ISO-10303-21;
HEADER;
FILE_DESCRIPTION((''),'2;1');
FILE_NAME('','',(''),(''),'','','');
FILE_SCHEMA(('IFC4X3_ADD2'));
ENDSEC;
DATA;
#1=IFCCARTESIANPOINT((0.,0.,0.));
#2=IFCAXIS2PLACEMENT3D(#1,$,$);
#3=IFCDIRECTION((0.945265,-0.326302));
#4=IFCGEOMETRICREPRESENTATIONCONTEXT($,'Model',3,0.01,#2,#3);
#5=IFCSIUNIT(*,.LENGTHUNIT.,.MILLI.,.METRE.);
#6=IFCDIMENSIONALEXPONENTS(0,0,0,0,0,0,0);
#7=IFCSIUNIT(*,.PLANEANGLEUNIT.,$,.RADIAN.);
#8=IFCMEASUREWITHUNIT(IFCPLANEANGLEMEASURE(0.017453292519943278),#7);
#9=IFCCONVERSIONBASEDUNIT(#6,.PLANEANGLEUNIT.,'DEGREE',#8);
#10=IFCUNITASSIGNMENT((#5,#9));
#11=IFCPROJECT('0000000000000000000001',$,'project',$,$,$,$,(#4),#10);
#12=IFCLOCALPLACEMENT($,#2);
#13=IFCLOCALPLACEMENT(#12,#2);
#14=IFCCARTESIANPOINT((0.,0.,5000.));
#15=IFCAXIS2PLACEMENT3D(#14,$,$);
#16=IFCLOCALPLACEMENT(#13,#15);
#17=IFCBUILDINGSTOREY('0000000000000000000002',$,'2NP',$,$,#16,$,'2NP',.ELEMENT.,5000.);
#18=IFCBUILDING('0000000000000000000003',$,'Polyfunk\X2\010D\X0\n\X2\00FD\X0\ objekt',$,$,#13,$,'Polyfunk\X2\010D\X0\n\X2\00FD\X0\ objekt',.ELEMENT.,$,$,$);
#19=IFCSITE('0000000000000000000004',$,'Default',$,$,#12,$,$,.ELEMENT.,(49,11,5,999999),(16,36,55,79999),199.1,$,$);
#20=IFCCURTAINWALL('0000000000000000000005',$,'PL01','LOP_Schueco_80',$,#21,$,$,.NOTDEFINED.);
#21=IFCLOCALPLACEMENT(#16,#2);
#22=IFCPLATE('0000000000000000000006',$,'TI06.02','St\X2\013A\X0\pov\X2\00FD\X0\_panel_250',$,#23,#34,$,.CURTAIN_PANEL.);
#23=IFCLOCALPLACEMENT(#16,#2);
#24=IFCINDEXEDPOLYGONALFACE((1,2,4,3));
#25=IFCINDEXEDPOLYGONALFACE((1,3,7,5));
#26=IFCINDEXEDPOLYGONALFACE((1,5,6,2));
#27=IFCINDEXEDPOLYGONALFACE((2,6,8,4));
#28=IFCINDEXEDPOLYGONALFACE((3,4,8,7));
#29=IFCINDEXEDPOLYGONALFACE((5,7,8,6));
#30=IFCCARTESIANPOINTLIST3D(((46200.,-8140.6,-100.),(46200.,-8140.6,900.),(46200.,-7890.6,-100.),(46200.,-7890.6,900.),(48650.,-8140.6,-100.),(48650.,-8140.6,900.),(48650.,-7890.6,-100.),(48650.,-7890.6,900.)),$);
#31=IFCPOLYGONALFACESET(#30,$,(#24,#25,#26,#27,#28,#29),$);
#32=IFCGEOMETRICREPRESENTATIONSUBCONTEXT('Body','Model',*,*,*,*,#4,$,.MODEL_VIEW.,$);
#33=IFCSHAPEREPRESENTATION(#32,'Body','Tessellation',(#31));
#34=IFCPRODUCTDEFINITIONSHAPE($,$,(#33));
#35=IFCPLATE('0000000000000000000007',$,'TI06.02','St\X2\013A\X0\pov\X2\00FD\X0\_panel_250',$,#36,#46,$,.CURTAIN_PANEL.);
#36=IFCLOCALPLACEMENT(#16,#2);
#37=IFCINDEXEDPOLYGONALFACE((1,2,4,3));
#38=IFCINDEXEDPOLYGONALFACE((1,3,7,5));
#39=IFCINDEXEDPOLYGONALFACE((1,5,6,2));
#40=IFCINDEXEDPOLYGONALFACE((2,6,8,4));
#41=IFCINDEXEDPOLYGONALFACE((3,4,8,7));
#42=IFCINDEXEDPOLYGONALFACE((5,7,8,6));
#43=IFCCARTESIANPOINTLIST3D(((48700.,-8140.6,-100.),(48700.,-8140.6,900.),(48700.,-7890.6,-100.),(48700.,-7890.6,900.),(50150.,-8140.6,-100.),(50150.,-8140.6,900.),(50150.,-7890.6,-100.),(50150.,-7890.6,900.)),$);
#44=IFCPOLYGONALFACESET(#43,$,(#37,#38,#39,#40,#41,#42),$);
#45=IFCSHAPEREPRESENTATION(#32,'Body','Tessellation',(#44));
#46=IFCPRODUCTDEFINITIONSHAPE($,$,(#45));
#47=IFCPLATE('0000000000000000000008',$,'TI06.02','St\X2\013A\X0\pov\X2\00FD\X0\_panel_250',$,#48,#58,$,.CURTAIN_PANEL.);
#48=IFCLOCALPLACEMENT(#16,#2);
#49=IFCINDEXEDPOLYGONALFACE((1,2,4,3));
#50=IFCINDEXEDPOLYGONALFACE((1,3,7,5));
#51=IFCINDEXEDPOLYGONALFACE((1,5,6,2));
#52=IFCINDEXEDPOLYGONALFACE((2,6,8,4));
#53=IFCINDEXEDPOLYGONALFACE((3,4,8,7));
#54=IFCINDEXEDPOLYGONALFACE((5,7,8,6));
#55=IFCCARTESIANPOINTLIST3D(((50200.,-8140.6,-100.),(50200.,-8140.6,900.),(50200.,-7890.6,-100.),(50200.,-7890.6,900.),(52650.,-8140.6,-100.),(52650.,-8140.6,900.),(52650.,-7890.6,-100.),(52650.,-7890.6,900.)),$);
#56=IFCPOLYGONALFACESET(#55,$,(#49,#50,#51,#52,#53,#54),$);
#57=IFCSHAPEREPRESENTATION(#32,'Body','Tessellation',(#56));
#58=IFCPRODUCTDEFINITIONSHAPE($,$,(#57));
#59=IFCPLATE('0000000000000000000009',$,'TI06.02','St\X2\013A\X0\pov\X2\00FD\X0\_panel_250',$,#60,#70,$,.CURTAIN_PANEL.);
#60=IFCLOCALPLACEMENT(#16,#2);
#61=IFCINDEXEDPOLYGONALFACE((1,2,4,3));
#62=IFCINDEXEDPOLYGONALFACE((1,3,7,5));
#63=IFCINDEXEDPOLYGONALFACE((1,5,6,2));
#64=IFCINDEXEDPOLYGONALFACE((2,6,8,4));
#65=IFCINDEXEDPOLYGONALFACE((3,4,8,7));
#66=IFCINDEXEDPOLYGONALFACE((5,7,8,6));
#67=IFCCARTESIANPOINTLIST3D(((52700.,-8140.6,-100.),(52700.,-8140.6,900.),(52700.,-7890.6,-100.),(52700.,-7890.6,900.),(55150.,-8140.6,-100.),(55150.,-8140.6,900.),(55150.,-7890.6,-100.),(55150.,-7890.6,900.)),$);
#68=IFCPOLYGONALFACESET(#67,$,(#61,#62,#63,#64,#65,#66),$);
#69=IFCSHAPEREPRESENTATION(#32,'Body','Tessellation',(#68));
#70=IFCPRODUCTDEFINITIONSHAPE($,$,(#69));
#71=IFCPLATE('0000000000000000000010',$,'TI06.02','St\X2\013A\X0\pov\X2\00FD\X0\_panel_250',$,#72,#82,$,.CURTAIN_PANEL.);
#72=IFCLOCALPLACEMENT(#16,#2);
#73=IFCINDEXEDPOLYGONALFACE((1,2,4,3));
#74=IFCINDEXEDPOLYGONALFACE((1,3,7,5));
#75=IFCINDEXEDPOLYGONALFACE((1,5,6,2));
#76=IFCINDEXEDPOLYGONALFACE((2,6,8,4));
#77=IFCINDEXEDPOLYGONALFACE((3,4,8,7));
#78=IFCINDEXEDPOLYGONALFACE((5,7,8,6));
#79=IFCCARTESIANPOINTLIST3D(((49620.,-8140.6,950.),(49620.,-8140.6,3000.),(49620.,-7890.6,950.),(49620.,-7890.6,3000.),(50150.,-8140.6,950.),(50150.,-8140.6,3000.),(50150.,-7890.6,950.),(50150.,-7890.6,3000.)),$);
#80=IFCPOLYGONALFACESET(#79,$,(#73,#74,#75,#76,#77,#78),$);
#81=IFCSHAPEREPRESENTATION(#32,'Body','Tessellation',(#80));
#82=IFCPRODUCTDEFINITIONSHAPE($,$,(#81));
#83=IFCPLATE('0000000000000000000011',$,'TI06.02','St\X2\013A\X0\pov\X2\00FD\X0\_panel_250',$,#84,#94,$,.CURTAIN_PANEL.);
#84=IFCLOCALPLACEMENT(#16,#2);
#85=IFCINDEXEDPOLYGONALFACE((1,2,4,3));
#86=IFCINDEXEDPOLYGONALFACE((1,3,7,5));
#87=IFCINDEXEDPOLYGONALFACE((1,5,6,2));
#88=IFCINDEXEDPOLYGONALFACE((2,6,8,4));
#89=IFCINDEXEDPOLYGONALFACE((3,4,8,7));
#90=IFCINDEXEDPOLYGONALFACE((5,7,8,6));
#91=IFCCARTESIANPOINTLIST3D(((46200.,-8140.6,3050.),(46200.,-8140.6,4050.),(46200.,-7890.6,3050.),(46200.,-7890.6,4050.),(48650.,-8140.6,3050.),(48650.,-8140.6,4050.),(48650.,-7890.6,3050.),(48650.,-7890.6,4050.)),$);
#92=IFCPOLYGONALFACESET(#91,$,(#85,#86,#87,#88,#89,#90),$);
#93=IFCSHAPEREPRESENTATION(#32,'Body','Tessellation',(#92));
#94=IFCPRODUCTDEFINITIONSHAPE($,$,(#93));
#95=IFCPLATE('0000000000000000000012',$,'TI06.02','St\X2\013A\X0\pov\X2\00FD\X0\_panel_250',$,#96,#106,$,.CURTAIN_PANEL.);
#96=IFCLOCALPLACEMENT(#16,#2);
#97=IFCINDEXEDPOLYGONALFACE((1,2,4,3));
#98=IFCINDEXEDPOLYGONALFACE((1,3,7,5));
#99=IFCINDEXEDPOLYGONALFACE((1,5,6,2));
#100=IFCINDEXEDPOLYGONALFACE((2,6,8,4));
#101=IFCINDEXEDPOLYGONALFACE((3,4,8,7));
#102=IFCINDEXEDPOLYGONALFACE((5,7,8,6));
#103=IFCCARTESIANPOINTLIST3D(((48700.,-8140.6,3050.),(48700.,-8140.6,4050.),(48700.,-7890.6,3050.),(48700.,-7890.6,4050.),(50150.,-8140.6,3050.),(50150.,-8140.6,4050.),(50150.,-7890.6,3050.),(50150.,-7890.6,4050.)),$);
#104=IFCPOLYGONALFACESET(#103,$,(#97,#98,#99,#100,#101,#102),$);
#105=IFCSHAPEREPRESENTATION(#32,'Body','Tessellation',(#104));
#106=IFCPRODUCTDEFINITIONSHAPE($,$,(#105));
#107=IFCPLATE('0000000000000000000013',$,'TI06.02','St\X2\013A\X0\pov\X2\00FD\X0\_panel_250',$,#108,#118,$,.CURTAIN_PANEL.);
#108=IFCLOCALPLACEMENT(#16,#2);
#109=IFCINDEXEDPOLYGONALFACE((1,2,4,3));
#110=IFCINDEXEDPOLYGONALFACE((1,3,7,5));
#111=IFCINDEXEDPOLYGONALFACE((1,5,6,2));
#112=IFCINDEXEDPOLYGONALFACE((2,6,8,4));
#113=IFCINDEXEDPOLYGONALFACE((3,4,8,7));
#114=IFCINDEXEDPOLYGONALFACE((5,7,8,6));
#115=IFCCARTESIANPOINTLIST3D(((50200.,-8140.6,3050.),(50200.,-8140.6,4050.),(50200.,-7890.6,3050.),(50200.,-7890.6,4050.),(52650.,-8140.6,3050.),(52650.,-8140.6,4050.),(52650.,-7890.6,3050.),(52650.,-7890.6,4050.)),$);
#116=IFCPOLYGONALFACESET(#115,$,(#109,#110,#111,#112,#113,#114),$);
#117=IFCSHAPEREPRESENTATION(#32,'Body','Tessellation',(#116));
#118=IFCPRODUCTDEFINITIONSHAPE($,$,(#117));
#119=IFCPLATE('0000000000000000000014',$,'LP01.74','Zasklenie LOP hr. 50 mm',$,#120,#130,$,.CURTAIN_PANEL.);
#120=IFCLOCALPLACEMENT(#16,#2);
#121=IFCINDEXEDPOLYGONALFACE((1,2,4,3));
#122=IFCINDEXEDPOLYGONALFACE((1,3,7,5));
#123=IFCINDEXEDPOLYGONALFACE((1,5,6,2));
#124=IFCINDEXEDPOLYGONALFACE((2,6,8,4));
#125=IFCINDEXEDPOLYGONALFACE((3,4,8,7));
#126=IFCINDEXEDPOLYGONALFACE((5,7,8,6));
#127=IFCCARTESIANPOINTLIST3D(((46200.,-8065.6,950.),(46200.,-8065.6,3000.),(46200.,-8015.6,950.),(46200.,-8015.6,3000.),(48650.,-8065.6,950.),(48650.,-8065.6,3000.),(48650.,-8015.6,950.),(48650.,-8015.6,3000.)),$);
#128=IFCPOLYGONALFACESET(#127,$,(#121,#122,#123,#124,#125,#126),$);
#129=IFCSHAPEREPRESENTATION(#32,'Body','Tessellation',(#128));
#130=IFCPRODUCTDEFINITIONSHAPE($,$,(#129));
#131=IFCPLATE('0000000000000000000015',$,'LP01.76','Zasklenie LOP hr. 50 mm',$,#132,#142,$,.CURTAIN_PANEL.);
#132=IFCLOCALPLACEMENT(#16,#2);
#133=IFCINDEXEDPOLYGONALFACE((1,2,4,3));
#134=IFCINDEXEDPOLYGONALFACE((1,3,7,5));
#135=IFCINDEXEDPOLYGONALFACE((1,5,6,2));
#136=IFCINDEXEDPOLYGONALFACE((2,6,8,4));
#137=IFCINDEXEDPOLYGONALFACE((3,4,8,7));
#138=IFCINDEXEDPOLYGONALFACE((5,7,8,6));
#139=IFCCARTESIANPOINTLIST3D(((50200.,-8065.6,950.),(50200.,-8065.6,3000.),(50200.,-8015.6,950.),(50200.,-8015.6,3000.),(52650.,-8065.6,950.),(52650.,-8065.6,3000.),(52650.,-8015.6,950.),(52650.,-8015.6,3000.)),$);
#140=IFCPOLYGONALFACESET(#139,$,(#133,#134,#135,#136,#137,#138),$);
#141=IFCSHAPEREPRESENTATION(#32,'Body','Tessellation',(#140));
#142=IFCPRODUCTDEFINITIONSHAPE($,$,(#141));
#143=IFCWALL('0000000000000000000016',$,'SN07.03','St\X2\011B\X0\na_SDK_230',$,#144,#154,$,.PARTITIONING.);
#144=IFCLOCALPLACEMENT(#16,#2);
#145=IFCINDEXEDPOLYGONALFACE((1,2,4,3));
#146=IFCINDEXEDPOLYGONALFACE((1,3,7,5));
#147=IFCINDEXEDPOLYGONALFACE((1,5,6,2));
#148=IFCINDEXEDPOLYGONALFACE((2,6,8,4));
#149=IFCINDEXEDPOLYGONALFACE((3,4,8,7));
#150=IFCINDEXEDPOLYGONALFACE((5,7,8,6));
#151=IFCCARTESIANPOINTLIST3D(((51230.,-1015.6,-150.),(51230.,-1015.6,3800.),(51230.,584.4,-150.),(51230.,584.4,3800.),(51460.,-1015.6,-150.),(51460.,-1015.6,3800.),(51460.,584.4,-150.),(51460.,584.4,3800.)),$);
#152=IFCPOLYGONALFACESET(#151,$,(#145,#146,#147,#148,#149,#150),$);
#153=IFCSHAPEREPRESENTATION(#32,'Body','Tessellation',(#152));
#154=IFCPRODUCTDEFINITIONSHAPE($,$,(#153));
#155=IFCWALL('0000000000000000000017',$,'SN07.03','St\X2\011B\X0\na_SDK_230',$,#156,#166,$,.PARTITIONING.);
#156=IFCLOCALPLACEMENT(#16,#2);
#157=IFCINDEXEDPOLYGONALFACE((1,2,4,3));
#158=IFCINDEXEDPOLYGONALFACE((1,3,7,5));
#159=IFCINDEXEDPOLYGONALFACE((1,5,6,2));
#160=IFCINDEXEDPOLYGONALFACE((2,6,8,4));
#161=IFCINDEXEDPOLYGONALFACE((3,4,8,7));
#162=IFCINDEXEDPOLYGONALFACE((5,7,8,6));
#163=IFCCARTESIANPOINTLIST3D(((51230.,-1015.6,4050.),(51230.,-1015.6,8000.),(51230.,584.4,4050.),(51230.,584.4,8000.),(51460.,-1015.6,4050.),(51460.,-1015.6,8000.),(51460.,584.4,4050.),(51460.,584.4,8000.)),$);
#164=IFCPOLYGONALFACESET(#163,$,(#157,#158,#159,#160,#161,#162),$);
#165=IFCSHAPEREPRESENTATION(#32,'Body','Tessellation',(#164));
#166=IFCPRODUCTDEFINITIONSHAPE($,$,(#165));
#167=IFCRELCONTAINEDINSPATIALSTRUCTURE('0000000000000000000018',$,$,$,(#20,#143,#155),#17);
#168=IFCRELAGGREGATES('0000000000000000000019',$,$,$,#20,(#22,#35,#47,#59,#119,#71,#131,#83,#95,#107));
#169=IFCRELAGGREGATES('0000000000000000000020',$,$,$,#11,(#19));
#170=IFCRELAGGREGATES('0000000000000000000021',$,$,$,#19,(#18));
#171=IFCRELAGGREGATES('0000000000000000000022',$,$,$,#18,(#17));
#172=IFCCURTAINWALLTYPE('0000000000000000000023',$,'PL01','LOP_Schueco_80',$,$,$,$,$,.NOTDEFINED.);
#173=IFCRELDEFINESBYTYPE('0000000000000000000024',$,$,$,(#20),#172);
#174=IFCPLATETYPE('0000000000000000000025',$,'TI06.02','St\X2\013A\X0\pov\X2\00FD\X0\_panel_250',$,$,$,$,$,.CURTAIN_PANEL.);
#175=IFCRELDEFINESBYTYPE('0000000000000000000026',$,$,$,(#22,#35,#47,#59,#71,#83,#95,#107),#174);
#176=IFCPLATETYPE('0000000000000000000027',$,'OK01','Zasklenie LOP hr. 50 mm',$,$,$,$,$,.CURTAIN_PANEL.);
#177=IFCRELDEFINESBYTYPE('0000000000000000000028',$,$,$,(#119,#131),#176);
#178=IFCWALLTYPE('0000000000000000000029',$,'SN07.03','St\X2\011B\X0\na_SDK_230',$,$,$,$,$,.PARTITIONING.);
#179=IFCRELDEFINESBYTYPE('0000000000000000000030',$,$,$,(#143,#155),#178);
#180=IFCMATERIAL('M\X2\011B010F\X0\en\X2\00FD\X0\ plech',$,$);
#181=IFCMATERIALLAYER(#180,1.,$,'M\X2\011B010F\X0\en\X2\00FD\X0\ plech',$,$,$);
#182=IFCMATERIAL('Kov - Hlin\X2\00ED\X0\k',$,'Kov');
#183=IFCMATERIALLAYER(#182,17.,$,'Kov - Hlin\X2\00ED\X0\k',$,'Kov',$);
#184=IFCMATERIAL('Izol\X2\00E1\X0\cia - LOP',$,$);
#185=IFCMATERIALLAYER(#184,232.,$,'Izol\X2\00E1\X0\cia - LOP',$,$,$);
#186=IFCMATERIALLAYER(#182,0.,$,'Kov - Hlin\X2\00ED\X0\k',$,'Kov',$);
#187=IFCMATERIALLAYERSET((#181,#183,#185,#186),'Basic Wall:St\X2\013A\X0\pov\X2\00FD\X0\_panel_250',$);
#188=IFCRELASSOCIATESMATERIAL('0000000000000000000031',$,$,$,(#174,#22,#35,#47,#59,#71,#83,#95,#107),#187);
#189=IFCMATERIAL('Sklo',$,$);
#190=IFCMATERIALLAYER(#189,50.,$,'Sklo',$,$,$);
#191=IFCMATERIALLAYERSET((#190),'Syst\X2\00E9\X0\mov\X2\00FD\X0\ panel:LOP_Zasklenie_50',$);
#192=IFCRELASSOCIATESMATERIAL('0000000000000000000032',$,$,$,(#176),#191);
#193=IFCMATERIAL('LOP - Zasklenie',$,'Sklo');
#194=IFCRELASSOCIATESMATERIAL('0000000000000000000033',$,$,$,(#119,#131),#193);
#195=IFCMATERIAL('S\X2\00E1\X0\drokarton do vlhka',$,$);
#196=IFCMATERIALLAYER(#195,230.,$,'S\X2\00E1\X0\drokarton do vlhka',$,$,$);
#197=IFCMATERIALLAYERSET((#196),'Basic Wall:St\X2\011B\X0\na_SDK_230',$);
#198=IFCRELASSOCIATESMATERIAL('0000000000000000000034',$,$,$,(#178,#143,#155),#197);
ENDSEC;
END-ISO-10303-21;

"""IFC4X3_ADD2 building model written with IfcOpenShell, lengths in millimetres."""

from ifc_helpers import new_model, entity, si_unit, converted_unit, direction, frame, frame_2d, origin, origin_2d_with_axis, place, context, subcontext, project, spatial, polyline, rectangle, extrude, clip, bounded_halfspace, source, transform, mapped, material, layer, layer_set, layer_usage, type_object, type_shapes, element, aggregate, save


model = new_model("IFC4X3_ADD2")

# Units and contexts
model_context = context("Model", 3, precision=0.01, world=origin(), true_north=direction((0.945265, -0.326302)))
body_context = subcontext(model_context, "Body", "Model", "MODEL_VIEW")
ifc_project = project(units=[si_unit("LENGTHUNIT", "METRE", prefix="MILLI"), converted_unit("PLANEANGLEUNIT", "DEGREE", entity("IfcPlaneAngleMeasure", 0.017453292519943278), si_unit("PLANEANGLEUNIT", "RADIAN"), dimensions=[0, 0, 0, 0, 0, 0, 0])], contexts=[model_context])

# Site, building, storey
site_placement = place(None, origin())
site = spatial("IfcSite", under=ifc_project, at=site_placement, Name="Default", CompositionType="ELEMENT", RefLatitude=(49, 11, 5, 999999), RefLongitude=(16, 36, 55, 79999), RefElevation=199.1)
building_placement = place(site_placement, origin())
building = spatial("IfcBuilding", under=site, at=building_placement, Name="Polyfunkčný objekt", LongName="Polyfunkčný objekt", CompositionType="ELEMENT")
storey_placement = place(building_placement, frame((0.0, 0.0, 5000.0)))
storey = spatial("IfcBuildingStorey", under=building, at=storey_placement, Name="2NP", LongName="2NP", CompositionType="ELEMENT", Elevation=5000.0)

# Curtain wall, plates
curtain_wall_type = type_object("IfcCurtainWallType", Name="PL01", Description="LOP_Schueco_80", PredefinedType="NOTDEFINED")
curtain_wall_placement = place(storey_placement, frame((0.0, 0.0, -5000.0)))
curtain_wall = element("IfcCurtainWall", 1, at=curtain_wall_placement, inside=storey, type_object=curtain_wall_type, Name="PL01", Description="LOP_Schueco_80", PredefinedType="NOTDEFINED")
ifc_material_1 = material(Name="Měďený plech")
ifc_layer_1 = layer(ifc_material_1, 1.0, Name="Měďený plech")
ifc_material_2 = material(Name="Kov - Hliník", Category="Kov")
ifc_layer_2 = layer(ifc_material_2, 17.0, Name="Kov - Hliník", Category="Kov")
ifc_material_3 = material(Name="Izolácia - LOP")
ifc_layer_3 = layer(ifc_material_3, 232.0, Name="Izolácia - LOP")
ifc_layer_4 = layer(ifc_material_2, 0.0, Name="Kov - Hliník", Category="Kov")
ifc_layer_set_1 = layer_set([ifc_layer_1, ifc_layer_2, ifc_layer_3, ifc_layer_4], Name="Basic Wall:Stĺpový_panel_250")
ifc_layer_usage_1 = layer_usage(ifc_layer_set_1, "AXIS2", "POSITIVE", -125.0)
plate_type_1 = type_object("IfcPlateType", Name="TI06.02", Description="Stĺpový_panel_250", PredefinedType="CURTAIN_PANEL", material=ifc_layer_set_1)
plate_1_placement = place(storey_placement, frame((46200.0, -8015.6, -100.0)))
plate_1 = element("IfcPlate", 2, at=plate_1_placement, type_object=plate_type_1, material=ifc_layer_usage_1, Name="TI06.02", Description="Stĺpový_panel_250", PredefinedType="CURTAIN_PANEL", context=body_context, shape_type="SweptSolid", body=[
    extrude(rectangle(XDim=250.0, YDim=2450.0, at=frame_2d((0.0, 0.0), x_axis=(1.0, 0.0))), frame((1225.0, 0.0, 0.0), z_axis=(0.0, 0.0, 1.0), x_axis=(0.0, 1.0, 0.0)), (0.0, 0.0, 1.0), 1000.0),
])
ifc_layer_usage_2 = layer_usage(ifc_layer_set_1, "AXIS2", "POSITIVE", -125.0)
plate_2_placement = place(storey_placement, frame((48700.0, -8015.6, -100.0)))
plate_2 = element("IfcPlate", 3, at=plate_2_placement, type_object=plate_type_1, material=ifc_layer_usage_2, Name="TI06.02", Description="Stĺpový_panel_250", PredefinedType="CURTAIN_PANEL", context=body_context, shape_type="SweptSolid", body=[
    extrude(rectangle(XDim=250.0, YDim=1450.0, at=frame_2d((0.0, 0.0), x_axis=(1.0, 0.0))), frame((725.0, 0.0, 0.0), z_axis=(0.0, 0.0, 1.0), x_axis=(0.0, 1.0, 0.0)), (0.0, 0.0, 1.0), 1000.0),
])
ifc_layer_usage_3 = layer_usage(ifc_layer_set_1, "AXIS2", "POSITIVE", -125.0)
plate_3_placement = place(storey_placement, frame((50200.0, -8015.6, -100.0)))
plate_3 = element("IfcPlate", 4, at=plate_3_placement, type_object=plate_type_1, material=ifc_layer_usage_3, Name="TI06.02", Description="Stĺpový_panel_250", PredefinedType="CURTAIN_PANEL", context=body_context, shape_type="SweptSolid", body=[
    extrude(rectangle(XDim=250.0, YDim=2450.0, at=origin_2d_with_axis()), frame((1225.0, 0.0, 0.0), z_axis=(0.0, 0.0, 1.0), x_axis=(0.0, 1.0, 0.0)), (0.0, 0.0, 1.0), 1000.0),
])
ifc_layer_usage_4 = layer_usage(ifc_layer_set_1, "AXIS2", "POSITIVE", -125.0)
plate_4_placement = place(storey_placement, frame((52700.0, -8015.6, -100.0)))
plate_4 = element("IfcPlate", 5, at=plate_4_placement, type_object=plate_type_1, material=ifc_layer_usage_4, Name="TI06.02", Description="Stĺpový_panel_250", PredefinedType="CURTAIN_PANEL", context=body_context, shape_type="SweptSolid", body=[
    extrude(rectangle(XDim=250.0, YDim=2450.0, at=frame_2d((0.0, 0.0), x_axis=(1.0, 0.0))), frame((1225.0, 0.0, 0.0), z_axis=(0.0, 0.0, 1.0), x_axis=(0.0, 1.0, 0.0)), (0.0, 0.0, 1.0), 1000.0),
])
ifc_layer_usage_5 = layer_usage(ifc_layer_set_1, "AXIS2", "POSITIVE", -125.0)
plate_5_placement = place(storey_placement, frame((49620.0, -8015.6, 950.0)))
plate_5 = element("IfcPlate", 6, at=plate_5_placement, type_object=plate_type_1, material=ifc_layer_usage_5, Name="TI06.02", Description="Stĺpový_panel_250", PredefinedType="CURTAIN_PANEL", context=body_context, shape_type="SweptSolid", body=[
    extrude(rectangle(XDim=250.0, YDim=530.0, at=frame_2d((0.0, 0.0), x_axis=(1.0, 0.0))), frame((265.0, 0.0, 0.0), z_axis=(0.0, 0.0, 1.0), x_axis=(0.0, 1.0, 0.0)), (0.0, 0.0, 1.0), 2050.0),
])
ifc_layer_usage_6 = layer_usage(ifc_layer_set_1, "AXIS2", "POSITIVE", -125.0)
plate_6_placement = place(storey_placement, frame((46200.0, -8015.6, 3050.0)))
plate_6 = element("IfcPlate", 7, at=plate_6_placement, type_object=plate_type_1, material=ifc_layer_usage_6, Name="TI06.02", Description="Stĺpový_panel_250", PredefinedType="CURTAIN_PANEL", context=body_context, shape_type="SweptSolid", body=[
    extrude(rectangle(XDim=250.0, YDim=2450.0, at=frame_2d((0.0, 0.0), x_axis=(1.0, 0.0))), frame((1225.0, 0.0, 0.0), z_axis=(0.0, 0.0, 1.0), x_axis=(0.0, 1.0, 0.0)), (0.0, 0.0, 1.0), 1000.0),
])
ifc_layer_usage_7 = layer_usage(ifc_layer_set_1, "AXIS2", "POSITIVE", -125.0)
plate_7_placement = place(storey_placement, frame((48700.0, -8015.6, 3050.0)))
plate_7 = element("IfcPlate", 8, at=plate_7_placement, type_object=plate_type_1, material=ifc_layer_usage_7, Name="TI06.02", Description="Stĺpový_panel_250", PredefinedType="CURTAIN_PANEL", context=body_context, shape_type="SweptSolid", body=[
    extrude(rectangle(XDim=250.0, YDim=1450.0, at=frame_2d((0.0, 0.0), x_axis=(1.0, 0.0))), frame((725.0, 0.0, 0.0), z_axis=(0.0, 0.0, 1.0), x_axis=(0.0, 1.0, 0.0)), (0.0, 0.0, 1.0), 1000.0),
])
ifc_layer_usage_8 = layer_usage(ifc_layer_set_1, "AXIS2", "POSITIVE", -125.0)
plate_8_placement = place(storey_placement, frame((50200.0, -8015.6, 3050.0)))
plate_8 = element("IfcPlate", 9, at=plate_8_placement, type_object=plate_type_1, material=ifc_layer_usage_8, Name="TI06.02", Description="Stĺpový_panel_250", PredefinedType="CURTAIN_PANEL", context=body_context, shape_type="SweptSolid", body=[
    extrude(rectangle(XDim=250.0, YDim=2450.0, at=origin_2d_with_axis()), frame((1225.0, 0.0, 0.0), z_axis=(0.0, 0.0, 1.0), x_axis=(0.0, 1.0, 0.0)), (0.0, 0.0, 1.0), 1000.0),
])
ifc_material_4 = material(Name="LOP - Zasklenie", Category="Sklo")
ifc_material_5 = material(Name="Sklo")
ifc_layer_5 = layer(ifc_material_5, 50.0, Name="Sklo")
ifc_layer_set_2 = layer_set([ifc_layer_5], Name="Systémový panel:LOP_Zasklenie_50")
plate_type_2 = type_object("IfcPlateType", Name="OK01", Description="Zasklenie LOP hr. 50 mm", PredefinedType="CURTAIN_PANEL", material=ifc_layer_set_2)
shared_shape_1 = source(origin(), body_context, "Body", "SweptSolid", [
    extrude(rectangle(XDim=50.0, YDim=2450.0, at=origin_2d_with_axis()), frame((0.0, -25.0, 0.0), z_axis=(0.0, 0.0, 1.0), x_axis=(0.0, 1.0, 0.0)), (0.0, 0.0, 1.0), 2050.0),
])
type_shapes(plate_type_2, [shared_shape_1])
plate_9_placement = place(curtain_wall_placement, frame((47425.0, -8015.6, 5950.0)))
plate_9 = element("IfcPlate", 10, at=plate_9_placement, type_object=plate_type_2, material=ifc_material_4, Name="LP01.74", Description="Zasklenie LOP hr. 50 mm", PredefinedType="CURTAIN_PANEL", context=body_context, shape_type="MappedRepresentation", body=[
    mapped(shared_shape_1, transform((0.0, 0.0, 0.0), scale=1.0)),
])
plate_10_placement = place(curtain_wall_placement, frame((51425.0, -8015.6, 5950.0)))
plate_10 = element("IfcPlate", 11, at=plate_10_placement, type_object=plate_type_2, material=ifc_material_4, Name="LP01.76", Description="Zasklenie LOP hr. 50 mm", PredefinedType="CURTAIN_PANEL", context=body_context, shape_type="MappedRepresentation", body=[
    mapped(shared_shape_1, transform((0.0, 0.0, 0.0), scale=1.0)),
])

# Walls
ifc_material_6 = material(Name="Sádrokarton do vlhka")
ifc_layer_6 = layer(ifc_material_6, 230.0, Name="Sádrokarton do vlhka")
ifc_layer_set_3 = layer_set([ifc_layer_6], Name="Basic Wall:Stěna_SDK_230")
wall_type_1 = type_object("IfcWallType", Name="SN07.03", Description="Stěna_SDK_230", PredefinedType="PARTITIONING", material=ifc_layer_set_3)
wall_1_placement = place(storey_placement, frame((51345.0, 584.4, -150.0), z_axis=(0.0, 0.0, 1.0), x_axis=(0.0, -1.0, 0.0)))
element("IfcWall", 12, at=wall_1_placement, inside=storey, type_object=wall_type_1, material=ifc_layer_set_3, Name="SN07.03", Description="Stěna_SDK_230", PredefinedType="PARTITIONING", context=body_context, shape_type="Clipping", body=[
    clip(clip(extrude(rectangle(XDim=1600.0, YDim=230.0, at=frame_2d((800.0, 0.0), x_axis=(-1.0, 0.0))), origin(), (0.0, 0.0, 1.0), 3950.0), bounded_halfspace(frame((1600.0, -115.0, 0.0), z_axis=(0.0, 0.0, 1.0), x_axis=(0.0, -1.0, 0.0)), True, frame((1600.0, -115.0, 0.0)), polyline([(0.0, 0.0), (0.0, 230.0), (-1600.0, 230.0), (-1600.0, 0.0), (0.0, 0.0)]))), bounded_halfspace(frame((0.0, -115.0, 3950.0), z_axis=(0.0, 0.0, -1.0), x_axis=(0.0, 1.0, 0.0)), True, frame((0.0, -115.0, 3950.0)), polyline([(0.0, 0.0), (1600.0, 0.0), (1600.0, 230.0), (0.0, 230.0), (0.0, 0.0)]))),
])
wall_2_placement = place(storey_placement, frame((51345.0, 584.4, 4050.0), z_axis=(0.0, 0.0, 1.0), x_axis=(0.0, -1.0, 0.0)))
element("IfcWall", 13, at=wall_2_placement, inside=storey, type_object=wall_type_1, material=ifc_layer_set_3, Name="SN07.03", Description="Stěna_SDK_230", PredefinedType="PARTITIONING", context=body_context, shape_type="Clipping", body=[
    clip(clip(extrude(rectangle(XDim=1600.0, YDim=230.0, at=frame_2d((800.0, 0.0), x_axis=(-1.0, 0.0))), origin(), (0.0, 0.0, 1.0), 3950.0), bounded_halfspace(frame((1600.0, -115.0, 0.0), z_axis=(0.0, 0.0, 1.0), x_axis=(0.0, -1.0, 0.0)), True, frame((1600.0, -115.0, 0.0)), polyline([(0.0, 0.0), (0.0, 230.0), (-1600.0, 230.0), (-1600.0, 0.0), (0.0, 0.0)]))), bounded_halfspace(frame((0.0, -115.0, 3950.0), z_axis=(0.0, 0.0, -1.0), x_axis=(0.0, 1.0, 0.0)), True, frame((0.0, -115.0, 3950.0)), polyline([(0.0, 0.0), (1600.0, 0.0), (1600.0, 230.0), (0.0, 230.0), (0.0, 0.0)]))),
])

aggregate(curtain_wall, [plate_1, plate_2, plate_3, plate_4, plate_9, plate_5, plate_10, plate_6, plate_7, plate_8])

save(model, "model.ifc")
